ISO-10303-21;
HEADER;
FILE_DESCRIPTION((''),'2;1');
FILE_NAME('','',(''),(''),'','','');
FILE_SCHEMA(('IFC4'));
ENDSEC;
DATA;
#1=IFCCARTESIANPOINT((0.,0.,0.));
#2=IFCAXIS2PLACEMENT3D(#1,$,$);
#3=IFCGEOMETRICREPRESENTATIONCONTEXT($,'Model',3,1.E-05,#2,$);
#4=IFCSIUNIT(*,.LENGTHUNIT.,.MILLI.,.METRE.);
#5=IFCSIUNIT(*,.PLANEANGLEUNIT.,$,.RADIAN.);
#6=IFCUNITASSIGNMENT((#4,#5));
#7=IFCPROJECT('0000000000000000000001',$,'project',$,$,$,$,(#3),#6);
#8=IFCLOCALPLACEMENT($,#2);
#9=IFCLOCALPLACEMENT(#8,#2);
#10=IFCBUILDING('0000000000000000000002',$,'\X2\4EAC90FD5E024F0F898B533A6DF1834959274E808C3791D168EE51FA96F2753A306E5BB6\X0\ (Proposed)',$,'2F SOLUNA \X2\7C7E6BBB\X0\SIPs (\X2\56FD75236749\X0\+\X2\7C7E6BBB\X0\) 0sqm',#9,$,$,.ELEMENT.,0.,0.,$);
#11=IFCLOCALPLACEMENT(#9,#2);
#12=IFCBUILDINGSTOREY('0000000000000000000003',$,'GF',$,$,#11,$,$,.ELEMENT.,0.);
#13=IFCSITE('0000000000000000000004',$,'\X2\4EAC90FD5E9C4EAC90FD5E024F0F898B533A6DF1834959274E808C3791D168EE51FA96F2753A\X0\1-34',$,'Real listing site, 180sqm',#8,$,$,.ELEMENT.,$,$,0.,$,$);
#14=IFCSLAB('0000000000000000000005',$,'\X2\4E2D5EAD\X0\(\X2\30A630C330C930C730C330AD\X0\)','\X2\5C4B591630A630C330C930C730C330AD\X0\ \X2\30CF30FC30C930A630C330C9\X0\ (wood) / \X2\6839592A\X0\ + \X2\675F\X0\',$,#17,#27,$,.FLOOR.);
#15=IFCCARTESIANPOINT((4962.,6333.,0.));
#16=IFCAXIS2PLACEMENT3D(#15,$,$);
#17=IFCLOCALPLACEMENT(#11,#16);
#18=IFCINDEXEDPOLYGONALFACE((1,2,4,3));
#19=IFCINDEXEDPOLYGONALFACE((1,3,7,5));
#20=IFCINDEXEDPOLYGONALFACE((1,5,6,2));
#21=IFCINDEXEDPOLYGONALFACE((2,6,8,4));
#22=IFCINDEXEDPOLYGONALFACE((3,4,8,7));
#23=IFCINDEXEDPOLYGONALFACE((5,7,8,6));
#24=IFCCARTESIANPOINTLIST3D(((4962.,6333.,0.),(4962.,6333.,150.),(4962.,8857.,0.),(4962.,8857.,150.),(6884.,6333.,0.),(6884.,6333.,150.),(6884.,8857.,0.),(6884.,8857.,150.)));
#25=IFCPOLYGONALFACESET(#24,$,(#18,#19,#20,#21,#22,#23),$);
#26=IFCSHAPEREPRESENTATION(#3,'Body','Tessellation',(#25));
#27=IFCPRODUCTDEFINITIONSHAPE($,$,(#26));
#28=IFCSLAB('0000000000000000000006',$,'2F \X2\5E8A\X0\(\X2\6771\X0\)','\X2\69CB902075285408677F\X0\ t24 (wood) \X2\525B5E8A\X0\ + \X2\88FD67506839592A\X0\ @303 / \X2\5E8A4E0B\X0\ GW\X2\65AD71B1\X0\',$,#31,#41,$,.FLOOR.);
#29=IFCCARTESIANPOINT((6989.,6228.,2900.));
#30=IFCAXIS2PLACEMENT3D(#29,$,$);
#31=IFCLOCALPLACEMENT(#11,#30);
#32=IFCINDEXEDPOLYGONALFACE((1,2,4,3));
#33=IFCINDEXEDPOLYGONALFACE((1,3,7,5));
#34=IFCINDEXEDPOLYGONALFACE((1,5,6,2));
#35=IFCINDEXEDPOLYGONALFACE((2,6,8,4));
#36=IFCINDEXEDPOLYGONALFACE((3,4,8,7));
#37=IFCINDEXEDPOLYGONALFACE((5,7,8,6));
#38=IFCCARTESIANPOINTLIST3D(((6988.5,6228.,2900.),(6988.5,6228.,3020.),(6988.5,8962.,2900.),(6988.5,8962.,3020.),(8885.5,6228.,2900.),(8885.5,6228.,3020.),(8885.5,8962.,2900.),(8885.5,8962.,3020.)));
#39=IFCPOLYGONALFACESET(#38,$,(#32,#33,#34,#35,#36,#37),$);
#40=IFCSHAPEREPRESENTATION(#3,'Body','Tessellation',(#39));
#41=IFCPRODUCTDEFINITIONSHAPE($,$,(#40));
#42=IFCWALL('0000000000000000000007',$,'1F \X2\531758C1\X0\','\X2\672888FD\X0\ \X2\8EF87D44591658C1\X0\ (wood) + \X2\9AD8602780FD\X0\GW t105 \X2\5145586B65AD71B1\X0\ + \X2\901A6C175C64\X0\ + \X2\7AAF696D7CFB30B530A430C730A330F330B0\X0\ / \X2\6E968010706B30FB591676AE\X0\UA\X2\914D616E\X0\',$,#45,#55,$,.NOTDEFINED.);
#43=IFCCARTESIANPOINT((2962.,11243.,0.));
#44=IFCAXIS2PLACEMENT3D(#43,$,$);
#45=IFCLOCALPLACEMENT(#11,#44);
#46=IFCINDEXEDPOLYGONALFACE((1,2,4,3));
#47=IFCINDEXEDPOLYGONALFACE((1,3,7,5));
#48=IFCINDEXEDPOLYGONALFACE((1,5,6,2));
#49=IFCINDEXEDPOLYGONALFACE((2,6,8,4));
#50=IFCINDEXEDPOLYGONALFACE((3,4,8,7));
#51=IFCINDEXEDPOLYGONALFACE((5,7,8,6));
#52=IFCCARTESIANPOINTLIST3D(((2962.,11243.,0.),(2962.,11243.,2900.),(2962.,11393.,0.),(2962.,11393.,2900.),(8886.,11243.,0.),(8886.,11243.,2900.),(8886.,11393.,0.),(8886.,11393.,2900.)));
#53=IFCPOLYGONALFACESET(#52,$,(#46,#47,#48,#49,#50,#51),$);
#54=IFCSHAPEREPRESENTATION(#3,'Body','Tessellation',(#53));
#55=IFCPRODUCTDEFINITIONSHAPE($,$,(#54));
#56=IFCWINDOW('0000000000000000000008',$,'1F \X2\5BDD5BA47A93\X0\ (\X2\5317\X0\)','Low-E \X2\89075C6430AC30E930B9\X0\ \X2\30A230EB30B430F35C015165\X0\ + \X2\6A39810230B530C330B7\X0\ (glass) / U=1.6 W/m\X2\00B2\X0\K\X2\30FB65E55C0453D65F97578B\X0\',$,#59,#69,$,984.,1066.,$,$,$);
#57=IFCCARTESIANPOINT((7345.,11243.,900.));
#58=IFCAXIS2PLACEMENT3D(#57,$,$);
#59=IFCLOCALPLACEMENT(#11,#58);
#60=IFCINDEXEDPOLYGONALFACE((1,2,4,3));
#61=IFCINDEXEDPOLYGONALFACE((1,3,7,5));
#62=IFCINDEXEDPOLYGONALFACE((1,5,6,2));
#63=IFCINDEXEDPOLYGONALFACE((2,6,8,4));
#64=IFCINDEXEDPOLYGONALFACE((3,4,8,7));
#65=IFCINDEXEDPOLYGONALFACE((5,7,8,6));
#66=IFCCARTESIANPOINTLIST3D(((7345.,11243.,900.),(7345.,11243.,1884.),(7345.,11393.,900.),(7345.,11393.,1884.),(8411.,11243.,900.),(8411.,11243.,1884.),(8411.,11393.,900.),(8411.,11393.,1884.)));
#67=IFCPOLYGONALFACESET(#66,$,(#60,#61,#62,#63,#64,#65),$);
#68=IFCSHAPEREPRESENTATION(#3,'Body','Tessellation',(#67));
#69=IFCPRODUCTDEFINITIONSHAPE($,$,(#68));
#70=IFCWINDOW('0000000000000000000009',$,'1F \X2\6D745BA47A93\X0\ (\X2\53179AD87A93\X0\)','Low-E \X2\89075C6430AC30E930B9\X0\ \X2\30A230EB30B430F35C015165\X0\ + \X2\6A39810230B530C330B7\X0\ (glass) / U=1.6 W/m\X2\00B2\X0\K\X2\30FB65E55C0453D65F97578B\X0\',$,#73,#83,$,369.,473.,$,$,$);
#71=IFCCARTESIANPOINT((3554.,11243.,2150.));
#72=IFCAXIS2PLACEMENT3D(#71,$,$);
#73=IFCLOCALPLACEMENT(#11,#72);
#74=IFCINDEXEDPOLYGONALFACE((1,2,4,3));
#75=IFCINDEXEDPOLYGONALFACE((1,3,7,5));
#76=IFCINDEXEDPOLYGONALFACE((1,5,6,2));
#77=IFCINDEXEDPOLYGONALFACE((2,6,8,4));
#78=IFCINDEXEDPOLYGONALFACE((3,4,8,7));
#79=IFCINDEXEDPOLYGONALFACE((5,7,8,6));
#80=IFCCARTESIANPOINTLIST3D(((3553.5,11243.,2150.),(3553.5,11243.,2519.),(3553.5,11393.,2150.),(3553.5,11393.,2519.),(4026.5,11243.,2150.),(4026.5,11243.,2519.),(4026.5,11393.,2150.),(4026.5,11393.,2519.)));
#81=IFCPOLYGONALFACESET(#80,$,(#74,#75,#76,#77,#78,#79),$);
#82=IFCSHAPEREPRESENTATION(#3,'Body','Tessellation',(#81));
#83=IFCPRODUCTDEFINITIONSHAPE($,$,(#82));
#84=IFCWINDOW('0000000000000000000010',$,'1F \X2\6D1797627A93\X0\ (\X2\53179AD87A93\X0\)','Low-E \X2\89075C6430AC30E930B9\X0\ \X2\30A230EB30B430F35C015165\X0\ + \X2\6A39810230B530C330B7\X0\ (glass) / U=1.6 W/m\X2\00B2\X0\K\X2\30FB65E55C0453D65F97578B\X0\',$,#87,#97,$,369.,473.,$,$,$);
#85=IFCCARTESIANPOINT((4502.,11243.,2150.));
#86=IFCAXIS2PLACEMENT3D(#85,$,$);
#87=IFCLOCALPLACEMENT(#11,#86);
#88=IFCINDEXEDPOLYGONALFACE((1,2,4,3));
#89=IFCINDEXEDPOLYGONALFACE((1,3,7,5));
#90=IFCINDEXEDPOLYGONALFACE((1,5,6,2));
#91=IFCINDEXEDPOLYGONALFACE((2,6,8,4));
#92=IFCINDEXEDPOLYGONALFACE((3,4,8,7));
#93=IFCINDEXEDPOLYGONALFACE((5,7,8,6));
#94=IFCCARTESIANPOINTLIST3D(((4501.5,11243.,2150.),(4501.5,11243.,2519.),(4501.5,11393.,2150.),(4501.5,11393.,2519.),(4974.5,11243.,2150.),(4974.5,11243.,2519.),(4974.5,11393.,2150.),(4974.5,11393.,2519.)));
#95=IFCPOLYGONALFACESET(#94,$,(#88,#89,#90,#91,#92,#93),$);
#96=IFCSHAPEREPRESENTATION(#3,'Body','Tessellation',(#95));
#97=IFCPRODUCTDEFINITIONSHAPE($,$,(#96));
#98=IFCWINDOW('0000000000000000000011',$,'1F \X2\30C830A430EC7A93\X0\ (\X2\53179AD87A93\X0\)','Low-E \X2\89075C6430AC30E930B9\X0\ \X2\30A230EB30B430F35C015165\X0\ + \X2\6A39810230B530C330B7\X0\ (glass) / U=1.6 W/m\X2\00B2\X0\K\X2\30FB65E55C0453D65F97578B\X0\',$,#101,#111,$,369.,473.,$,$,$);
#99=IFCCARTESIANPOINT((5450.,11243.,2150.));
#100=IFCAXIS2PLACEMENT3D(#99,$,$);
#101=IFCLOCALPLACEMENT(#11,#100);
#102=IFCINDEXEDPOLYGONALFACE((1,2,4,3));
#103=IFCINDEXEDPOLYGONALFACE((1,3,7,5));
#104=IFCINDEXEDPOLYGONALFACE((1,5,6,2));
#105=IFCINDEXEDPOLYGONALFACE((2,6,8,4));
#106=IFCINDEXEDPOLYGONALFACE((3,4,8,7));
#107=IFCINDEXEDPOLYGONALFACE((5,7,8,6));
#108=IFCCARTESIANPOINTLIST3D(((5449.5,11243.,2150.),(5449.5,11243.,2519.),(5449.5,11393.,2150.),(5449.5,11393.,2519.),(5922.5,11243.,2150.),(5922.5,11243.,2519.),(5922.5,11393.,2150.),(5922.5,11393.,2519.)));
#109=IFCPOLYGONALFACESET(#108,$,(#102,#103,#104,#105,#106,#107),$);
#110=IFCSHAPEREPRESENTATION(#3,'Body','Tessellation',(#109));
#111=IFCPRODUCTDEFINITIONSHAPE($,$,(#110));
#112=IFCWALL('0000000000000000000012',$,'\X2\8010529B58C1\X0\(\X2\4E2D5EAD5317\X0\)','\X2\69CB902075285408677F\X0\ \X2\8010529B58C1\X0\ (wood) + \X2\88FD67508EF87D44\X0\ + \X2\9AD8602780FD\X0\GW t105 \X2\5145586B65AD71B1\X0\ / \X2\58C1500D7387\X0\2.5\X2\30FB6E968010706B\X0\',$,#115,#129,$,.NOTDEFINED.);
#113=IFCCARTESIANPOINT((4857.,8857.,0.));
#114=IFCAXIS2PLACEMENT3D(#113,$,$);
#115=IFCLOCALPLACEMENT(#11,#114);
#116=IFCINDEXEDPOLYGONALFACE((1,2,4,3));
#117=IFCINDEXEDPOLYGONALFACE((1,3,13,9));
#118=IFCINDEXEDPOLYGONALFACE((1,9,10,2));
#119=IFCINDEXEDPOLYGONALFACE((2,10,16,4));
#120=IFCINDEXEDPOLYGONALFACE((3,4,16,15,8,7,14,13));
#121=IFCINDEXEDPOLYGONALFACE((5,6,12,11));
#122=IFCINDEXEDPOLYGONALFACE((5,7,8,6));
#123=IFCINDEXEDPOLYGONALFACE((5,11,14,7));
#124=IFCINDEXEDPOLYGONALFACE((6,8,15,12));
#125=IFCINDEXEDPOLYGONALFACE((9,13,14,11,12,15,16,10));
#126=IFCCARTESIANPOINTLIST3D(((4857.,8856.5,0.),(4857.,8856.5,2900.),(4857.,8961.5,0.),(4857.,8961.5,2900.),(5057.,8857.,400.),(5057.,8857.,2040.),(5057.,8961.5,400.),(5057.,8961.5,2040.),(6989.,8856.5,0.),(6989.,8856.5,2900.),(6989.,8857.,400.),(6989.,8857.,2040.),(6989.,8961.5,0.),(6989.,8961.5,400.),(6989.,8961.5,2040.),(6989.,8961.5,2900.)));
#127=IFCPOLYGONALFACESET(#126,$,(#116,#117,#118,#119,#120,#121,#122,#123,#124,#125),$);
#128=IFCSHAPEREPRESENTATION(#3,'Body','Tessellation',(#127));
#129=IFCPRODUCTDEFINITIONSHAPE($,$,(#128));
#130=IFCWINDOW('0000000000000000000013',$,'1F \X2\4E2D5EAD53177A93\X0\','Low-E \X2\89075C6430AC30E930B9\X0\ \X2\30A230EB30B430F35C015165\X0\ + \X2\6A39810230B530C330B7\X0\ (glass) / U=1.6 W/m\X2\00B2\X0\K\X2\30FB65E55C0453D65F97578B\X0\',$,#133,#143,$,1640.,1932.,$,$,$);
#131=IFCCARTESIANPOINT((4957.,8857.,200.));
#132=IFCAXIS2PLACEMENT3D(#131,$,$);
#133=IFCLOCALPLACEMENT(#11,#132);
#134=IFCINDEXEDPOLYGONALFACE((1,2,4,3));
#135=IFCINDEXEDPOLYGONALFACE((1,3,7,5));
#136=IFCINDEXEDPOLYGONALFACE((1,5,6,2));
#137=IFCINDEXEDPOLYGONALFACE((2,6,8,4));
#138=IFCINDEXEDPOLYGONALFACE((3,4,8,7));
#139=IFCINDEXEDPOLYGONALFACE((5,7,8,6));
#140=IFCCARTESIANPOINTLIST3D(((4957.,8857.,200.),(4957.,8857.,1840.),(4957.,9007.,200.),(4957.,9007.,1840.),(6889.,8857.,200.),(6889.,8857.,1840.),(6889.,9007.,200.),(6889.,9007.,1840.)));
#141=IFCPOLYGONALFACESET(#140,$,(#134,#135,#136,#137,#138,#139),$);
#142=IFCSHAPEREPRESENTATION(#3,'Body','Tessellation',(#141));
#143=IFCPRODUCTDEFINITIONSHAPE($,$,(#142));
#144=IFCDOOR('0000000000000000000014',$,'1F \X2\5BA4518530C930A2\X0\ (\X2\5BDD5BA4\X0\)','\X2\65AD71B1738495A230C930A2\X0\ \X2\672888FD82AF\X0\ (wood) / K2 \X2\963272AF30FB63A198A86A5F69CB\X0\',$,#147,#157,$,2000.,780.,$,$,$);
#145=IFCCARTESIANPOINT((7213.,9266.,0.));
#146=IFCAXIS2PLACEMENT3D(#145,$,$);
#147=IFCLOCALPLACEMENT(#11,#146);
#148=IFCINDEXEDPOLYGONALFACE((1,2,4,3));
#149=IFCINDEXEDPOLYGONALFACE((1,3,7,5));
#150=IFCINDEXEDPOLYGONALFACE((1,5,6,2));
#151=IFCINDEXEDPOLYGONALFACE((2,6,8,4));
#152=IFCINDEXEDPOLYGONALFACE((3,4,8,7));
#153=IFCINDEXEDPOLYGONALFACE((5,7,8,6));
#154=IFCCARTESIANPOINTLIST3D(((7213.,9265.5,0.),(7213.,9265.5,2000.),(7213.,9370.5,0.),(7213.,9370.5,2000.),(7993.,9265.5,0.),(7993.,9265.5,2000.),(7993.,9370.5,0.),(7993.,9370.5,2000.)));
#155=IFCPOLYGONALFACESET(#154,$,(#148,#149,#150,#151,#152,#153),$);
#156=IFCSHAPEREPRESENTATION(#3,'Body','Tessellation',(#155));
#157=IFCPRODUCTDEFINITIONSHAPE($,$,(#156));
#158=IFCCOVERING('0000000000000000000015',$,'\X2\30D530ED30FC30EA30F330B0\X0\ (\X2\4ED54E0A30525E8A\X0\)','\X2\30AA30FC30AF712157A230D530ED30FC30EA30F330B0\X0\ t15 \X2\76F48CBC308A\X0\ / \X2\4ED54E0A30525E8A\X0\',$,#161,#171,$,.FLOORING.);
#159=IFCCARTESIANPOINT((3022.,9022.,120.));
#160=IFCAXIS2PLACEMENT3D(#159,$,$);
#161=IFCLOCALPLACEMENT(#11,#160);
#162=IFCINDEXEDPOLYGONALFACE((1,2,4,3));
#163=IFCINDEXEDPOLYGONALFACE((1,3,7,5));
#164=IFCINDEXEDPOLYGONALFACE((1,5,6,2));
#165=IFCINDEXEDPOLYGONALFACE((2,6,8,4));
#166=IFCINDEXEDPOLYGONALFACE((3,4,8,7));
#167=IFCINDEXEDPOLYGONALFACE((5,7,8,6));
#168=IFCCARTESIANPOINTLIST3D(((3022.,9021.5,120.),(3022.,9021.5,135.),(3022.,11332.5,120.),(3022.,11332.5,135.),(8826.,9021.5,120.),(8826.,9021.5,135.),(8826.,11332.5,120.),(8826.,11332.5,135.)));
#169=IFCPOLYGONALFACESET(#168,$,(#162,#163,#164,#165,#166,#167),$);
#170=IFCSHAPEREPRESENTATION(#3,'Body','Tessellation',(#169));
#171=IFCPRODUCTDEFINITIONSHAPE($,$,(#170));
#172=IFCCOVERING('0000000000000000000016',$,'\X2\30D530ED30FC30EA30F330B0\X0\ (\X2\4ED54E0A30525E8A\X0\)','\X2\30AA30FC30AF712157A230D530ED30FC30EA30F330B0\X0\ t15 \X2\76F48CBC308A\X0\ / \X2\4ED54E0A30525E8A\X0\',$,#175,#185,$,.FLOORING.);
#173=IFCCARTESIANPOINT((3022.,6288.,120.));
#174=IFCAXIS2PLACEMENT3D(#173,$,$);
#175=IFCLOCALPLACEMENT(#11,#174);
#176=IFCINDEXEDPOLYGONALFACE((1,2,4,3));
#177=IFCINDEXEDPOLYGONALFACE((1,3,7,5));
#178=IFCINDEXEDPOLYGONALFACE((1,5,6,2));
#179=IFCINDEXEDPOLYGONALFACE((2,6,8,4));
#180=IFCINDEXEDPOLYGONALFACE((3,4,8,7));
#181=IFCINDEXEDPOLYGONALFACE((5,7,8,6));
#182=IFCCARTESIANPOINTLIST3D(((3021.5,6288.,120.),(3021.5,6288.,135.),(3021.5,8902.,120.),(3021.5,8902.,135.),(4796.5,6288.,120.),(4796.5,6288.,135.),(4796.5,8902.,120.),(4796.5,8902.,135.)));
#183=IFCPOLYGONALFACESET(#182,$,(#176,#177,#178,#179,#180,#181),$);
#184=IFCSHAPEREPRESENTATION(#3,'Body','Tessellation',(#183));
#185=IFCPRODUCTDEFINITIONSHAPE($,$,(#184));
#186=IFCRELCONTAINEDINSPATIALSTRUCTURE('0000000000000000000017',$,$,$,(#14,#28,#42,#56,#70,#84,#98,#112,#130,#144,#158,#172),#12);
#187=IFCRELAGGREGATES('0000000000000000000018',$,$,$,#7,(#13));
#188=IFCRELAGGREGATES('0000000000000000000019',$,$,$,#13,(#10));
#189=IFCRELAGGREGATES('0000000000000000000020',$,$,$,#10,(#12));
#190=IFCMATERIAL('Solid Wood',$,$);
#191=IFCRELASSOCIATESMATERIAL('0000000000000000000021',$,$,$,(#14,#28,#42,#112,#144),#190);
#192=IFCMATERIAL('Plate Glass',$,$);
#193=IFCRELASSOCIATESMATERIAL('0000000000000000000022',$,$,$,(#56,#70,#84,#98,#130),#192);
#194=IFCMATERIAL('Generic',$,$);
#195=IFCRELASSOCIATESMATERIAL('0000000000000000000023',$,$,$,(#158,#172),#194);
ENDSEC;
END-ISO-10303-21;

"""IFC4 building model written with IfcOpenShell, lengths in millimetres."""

from ifc_helpers import new_model, si_unit, frame, frame_2d, origin, place, context, project, spatial, rectangle, extrude, material, element, fill, save


model = new_model("IFC4")

# Units and contexts
model_context = context("Model", 3, precision=1e-05, world=origin())
ifc_project = project(units=[si_unit("LENGTHUNIT", "METRE", prefix="MILLI"), si_unit("PLANEANGLEUNIT", "RADIAN")], contexts=[model_context])

# Site, building, storey
site_placement = place(None, origin())
site = spatial("IfcSite", under=ifc_project, at=site_placement, Name="京都府京都市伏見区深草大亀谷金森出雲町1-34", ObjectType="Real listing site, 180sqm", CompositionType="ELEMENT", RefElevation=0.0)
building_placement = place(site_placement, origin())
building = spatial("IfcBuilding", under=site, at=building_placement, Name="京都市伏見区深草大亀谷金森出雲町の家 (Proposed)", ObjectType="2F SOLUNA 籾殻SIPs (国産杉+籾殻) 0sqm", CompositionType="ELEMENT", ElevationOfRefHeight=0.0, ElevationOfTerrain=0.0)
storey_placement = place(building_placement, origin())
storey = spatial("IfcBuildingStorey", under=building, at=storey_placement, Name="GF", CompositionType="ELEMENT", Elevation=0.0)

# Slabs
ifc_material_1 = material(Name="Solid Wood")
slab_1_placement = place(storey_placement, frame((4962.0, 6333.0, 0.0)))
element("IfcSlab", 1, at=slab_1_placement, inside=storey, material=ifc_material_1, Name="中庭(ウッドデッキ)", Description="屋外ウッドデッキ ハードウッド (wood) / 根太 + 束", PredefinedType="FLOOR", context=model_context, shape_type="SweptSolid", body=[
    extrude(rectangle(XDim=1922.0, YDim=2524.0, at=frame_2d((961.0, 1262.0))), frame((4962.0, 6333.0, 0.0)), (0.0, 0.0, 1.0), 150.0),
])
slab_2_placement = place(storey_placement, frame((6989.0, 6228.0, 2900.0)))
element("IfcSlab", 2, at=slab_2_placement, inside=storey, material=ifc_material_1, Name="2F 床(東)", Description="構造用合板 t24 (wood) 剛床 + 製材根太 @303 / 床下 GW断熱", PredefinedType="FLOOR", context=model_context, shape_type="SweptSolid", body=[
    extrude(rectangle(XDim=1897.0, YDim=2734.0, at=frame_2d((948.0, 1367.0))), frame((6989.0, 6228.0, 2900.0)), (0.0, 0.0, 1.0), 120.0),
])

# Wall, openings, windows
wall_1_placement = place(storey_placement, frame((2962.0, 11243.0, 0.0)))
wall_1 = element("IfcWall", 3, at=wall_1_placement, inside=storey, material=ifc_material_1, Name="1F 北壁", Description="木製 軸組外壁 (wood) + 高性能GW t105 充填断熱 + 通気層 + 窯業系サイディング / 準耐火・外皮UA配慮", PredefinedType="NOTDEFINED", context=model_context, shape_type="SweptSolid", body=[
    extrude(rectangle(XDim=5924.0, YDim=150.0, at=frame_2d((2962.0, 75.0))), frame((2962.0, 11243.0, 0.0)), (0.0, 0.0, 1.0), 2900.0),
])
opening_1_placement = place(storey_placement, frame((7345.0, 11243.0, 900.0)))
opening_1 = element("IfcOpeningElement", 4, at=opening_1_placement, cuts=wall_1, PredefinedType="NOTDEFINED", context=model_context, shape_type="SweptSolid", body=[
    extrude(rectangle(XDim=1066.0, YDim=150.0, at=frame_2d((533.0, 75.0))), frame((7345.0, 11243.0, 900.0)), (0.0, 0.0, 1.0), 984.0),
])
opening_2_placement = place(storey_placement, frame((3554.0, 11243.0, 2150.0)))
opening_2 = element("IfcOpeningElement", 5, at=opening_2_placement, cuts=wall_1, PredefinedType="NOTDEFINED", context=model_context, shape_type="SweptSolid", body=[
    extrude(rectangle(XDim=473.0, YDim=150.0, at=frame_2d((236.0, 75.0))), frame((3554.0, 11243.0, 2150.0)), (0.0, 0.0, 1.0), 369.0),
])
opening_3_placement = place(storey_placement, frame((4502.0, 11243.0, 2150.0)))
opening_3 = element("IfcOpeningElement", 6, at=opening_3_placement, cuts=wall_1, PredefinedType="NOTDEFINED", context=model_context, shape_type="SweptSolid", body=[
    extrude(rectangle(XDim=473.0, YDim=150.0, at=frame_2d((236.0, 75.0))), frame((4502.0, 11243.0, 2150.0)), (0.0, 0.0, 1.0), 369.0),
])
opening_4_placement = place(storey_placement, frame((5450.0, 11243.0, 2150.0)))
opening_4 = element("IfcOpeningElement", 7, at=opening_4_placement, cuts=wall_1, PredefinedType="NOTDEFINED", context=model_context, shape_type="SweptSolid", body=[
    extrude(rectangle(XDim=473.0, YDim=150.0, at=frame_2d((236.0, 75.0))), frame((5450.0, 11243.0, 2150.0)), (0.0, 0.0, 1.0), 369.0),
])
ifc_material_2 = material(Name="Plate Glass")
window_1_placement = place(storey_placement, frame((7345.0, 11243.0, 900.0)))
window_1 = element("IfcWindow", 8, at=window_1_placement, inside=storey, material=ifc_material_2, Name="1F 寝室窓 (北)", Description="Low-E 複層ガラス アルゴン封入 + 樹脂サッシ (glass) / U=1.6 W/m²K・日射取得型", OverallHeight=984.0, OverallWidth=1066.0, context=model_context, shape_type="SweptSolid", body=[
    extrude(rectangle(XDim=1066.0, YDim=150.0, at=frame_2d((533.0, 75.0))), frame((7345.0, 11243.0, 900.0)), (0.0, 0.0, 1.0), 984.0),
])
fill(opening_1, window_1)
window_2_placement = place(storey_placement, frame((3554.0, 11243.0, 2150.0)))
window_2 = element("IfcWindow", 9, at=window_2_placement, inside=storey, material=ifc_material_2, Name="1F 浴室窓 (北高窓)", Description="Low-E 複層ガラス アルゴン封入 + 樹脂サッシ (glass) / U=1.6 W/m²K・日射取得型", OverallHeight=369.0, OverallWidth=473.0, context=model_context, shape_type="SweptSolid", body=[
    extrude(rectangle(XDim=473.0, YDim=150.0, at=frame_2d((236.0, 75.0))), frame((3554.0, 11243.0, 2150.0)), (0.0, 0.0, 1.0), 369.0),
])
fill(opening_2, window_2)
window_3_placement = place(storey_placement, frame((4502.0, 11243.0, 2150.0)))
window_3 = element("IfcWindow", 10, at=window_3_placement, inside=storey, material=ifc_material_2, Name="1F 洗面窓 (北高窓)", Description="Low-E 複層ガラス アルゴン封入 + 樹脂サッシ (glass) / U=1.6 W/m²K・日射取得型", OverallHeight=369.0, OverallWidth=473.0, context=model_context, shape_type="SweptSolid", body=[
    extrude(rectangle(XDim=473.0, YDim=150.0, at=frame_2d((236.0, 75.0))), frame((4502.0, 11243.0, 2150.0)), (0.0, 0.0, 1.0), 369.0),
])
fill(opening_3, window_3)
window_4_placement = place(storey_placement, frame((5450.0, 11243.0, 2150.0)))
window_4 = element("IfcWindow", 11, at=window_4_placement, inside=storey, material=ifc_material_2, Name="1F トイレ窓 (北高窓)", Description="Low-E 複層ガラス アルゴン封入 + 樹脂サッシ (glass) / U=1.6 W/m²K・日射取得型", OverallHeight=369.0, OverallWidth=473.0, context=model_context, shape_type="SweptSolid", body=[
    extrude(rectangle(XDim=473.0, YDim=150.0, at=frame_2d((236.0, 75.0))), frame((5450.0, 11243.0, 2150.0)), (0.0, 0.0, 1.0), 369.0),
])
fill(opening_4, window_4)

# Wall, opening, window
wall_2_placement = place(storey_placement, frame((4857.0, 8857.0, 0.0)))
wall_2 = element("IfcWall", 12, at=wall_2_placement, inside=storey, material=ifc_material_1, Name="耐力壁(中庭北)", Description="構造用合板 耐力壁 (wood) + 製材軸組 + 高性能GW t105 充填断熱 / 壁倍率2.5・準耐火", PredefinedType="NOTDEFINED", context=model_context, shape_type="SweptSolid", body=[
    extrude(rectangle(XDim=2132.0, YDim=105.0, at=frame_2d((1066.0, 52.0))), frame((4857.0, 8857.0, 0.0)), (0.0, 0.0, 1.0), 2900.0),
])
opening_5_placement = place(storey_placement, frame((4957.0, 8857.0, 200.0)))
opening_5 = element("IfcOpeningElement", 13, at=opening_5_placement, cuts=wall_2, PredefinedType="NOTDEFINED", context=model_context, shape_type="SweptSolid", body=[
    extrude(rectangle(XDim=1932.0, YDim=150.0, at=frame_2d((966.0, 75.0))), frame((4957.0, 8857.0, 200.0)), (0.0, 0.0, 1.0), 1640.0),
])
window_5_placement = place(storey_placement, frame((4957.0, 8857.0, 200.0)))
window_5 = element("IfcWindow", 14, at=window_5_placement, inside=storey, material=ifc_material_2, Name="1F 中庭北窓", Description="Low-E 複層ガラス アルゴン封入 + 樹脂サッシ (glass) / U=1.6 W/m²K・日射取得型", OverallHeight=1640.0, OverallWidth=1932.0, context=model_context, shape_type="SweptSolid", body=[
    extrude(rectangle(XDim=1932.0, YDim=150.0, at=frame_2d((966.0, 75.0))), frame((4957.0, 8857.0, 200.0)), (0.0, 0.0, 1.0), 1640.0),
])
fill(opening_5, window_5)

# Door
door_1_placement = place(storey_placement, frame((7213.0, 9266.0, 0.0)))
element("IfcDoor", 15, at=door_1_placement, inside=storey, material=ifc_material_1, Name="1F 室内ドア (寝室)", Description="断熱玄関ドア 木製芯 (wood) / K2 防犯・採風機構", OverallHeight=2000.0, OverallWidth=780.0, context=model_context, shape_type="SweptSolid", body=[
    extrude(rectangle(XDim=780.0, YDim=105.0, at=frame_2d((390.0, 52.0))), frame((7213.0, 9266.0, 0.0)), (0.0, 0.0, 1.0), 2000.0),
])

# Coverings
ifc_material_3 = material(Name="Generic")
covering_1_placement = place(storey_placement, frame((3022.0, 9022.0, 120.0)))
element("IfcCovering", 16, at=covering_1_placement, inside=storey, material=ifc_material_3, Name="フローリング (仕上げ床)", Description="オーク無垢フローリング t15 直貼り / 仕上げ床", PredefinedType="FLOORING", context=model_context, shape_type="SweptSolid", body=[
    extrude(rectangle(XDim=5804.0, YDim=2311.0, at=frame_2d((2902.0, 1155.0))), frame((3022.0, 9022.0, 120.0)), (0.0, 0.0, 1.0), 15.0),
])
covering_2_placement = place(storey_placement, frame((3022.0, 6288.0, 120.0)))
element("IfcCovering", 17, at=covering_2_placement, inside=storey, material=ifc_material_3, Name="フローリング (仕上げ床)", Description="オーク無垢フローリング t15 直貼り / 仕上げ床", PredefinedType="FLOORING", context=model_context, shape_type="SweptSolid", body=[
    extrude(rectangle(XDim=1775.0, YDim=2614.0, at=frame_2d((887.0, 1307.0))), frame((3022.0, 6288.0, 120.0)), (0.0, 0.0, 1.0), 15.0),
])

save(model, "model.ifc")
